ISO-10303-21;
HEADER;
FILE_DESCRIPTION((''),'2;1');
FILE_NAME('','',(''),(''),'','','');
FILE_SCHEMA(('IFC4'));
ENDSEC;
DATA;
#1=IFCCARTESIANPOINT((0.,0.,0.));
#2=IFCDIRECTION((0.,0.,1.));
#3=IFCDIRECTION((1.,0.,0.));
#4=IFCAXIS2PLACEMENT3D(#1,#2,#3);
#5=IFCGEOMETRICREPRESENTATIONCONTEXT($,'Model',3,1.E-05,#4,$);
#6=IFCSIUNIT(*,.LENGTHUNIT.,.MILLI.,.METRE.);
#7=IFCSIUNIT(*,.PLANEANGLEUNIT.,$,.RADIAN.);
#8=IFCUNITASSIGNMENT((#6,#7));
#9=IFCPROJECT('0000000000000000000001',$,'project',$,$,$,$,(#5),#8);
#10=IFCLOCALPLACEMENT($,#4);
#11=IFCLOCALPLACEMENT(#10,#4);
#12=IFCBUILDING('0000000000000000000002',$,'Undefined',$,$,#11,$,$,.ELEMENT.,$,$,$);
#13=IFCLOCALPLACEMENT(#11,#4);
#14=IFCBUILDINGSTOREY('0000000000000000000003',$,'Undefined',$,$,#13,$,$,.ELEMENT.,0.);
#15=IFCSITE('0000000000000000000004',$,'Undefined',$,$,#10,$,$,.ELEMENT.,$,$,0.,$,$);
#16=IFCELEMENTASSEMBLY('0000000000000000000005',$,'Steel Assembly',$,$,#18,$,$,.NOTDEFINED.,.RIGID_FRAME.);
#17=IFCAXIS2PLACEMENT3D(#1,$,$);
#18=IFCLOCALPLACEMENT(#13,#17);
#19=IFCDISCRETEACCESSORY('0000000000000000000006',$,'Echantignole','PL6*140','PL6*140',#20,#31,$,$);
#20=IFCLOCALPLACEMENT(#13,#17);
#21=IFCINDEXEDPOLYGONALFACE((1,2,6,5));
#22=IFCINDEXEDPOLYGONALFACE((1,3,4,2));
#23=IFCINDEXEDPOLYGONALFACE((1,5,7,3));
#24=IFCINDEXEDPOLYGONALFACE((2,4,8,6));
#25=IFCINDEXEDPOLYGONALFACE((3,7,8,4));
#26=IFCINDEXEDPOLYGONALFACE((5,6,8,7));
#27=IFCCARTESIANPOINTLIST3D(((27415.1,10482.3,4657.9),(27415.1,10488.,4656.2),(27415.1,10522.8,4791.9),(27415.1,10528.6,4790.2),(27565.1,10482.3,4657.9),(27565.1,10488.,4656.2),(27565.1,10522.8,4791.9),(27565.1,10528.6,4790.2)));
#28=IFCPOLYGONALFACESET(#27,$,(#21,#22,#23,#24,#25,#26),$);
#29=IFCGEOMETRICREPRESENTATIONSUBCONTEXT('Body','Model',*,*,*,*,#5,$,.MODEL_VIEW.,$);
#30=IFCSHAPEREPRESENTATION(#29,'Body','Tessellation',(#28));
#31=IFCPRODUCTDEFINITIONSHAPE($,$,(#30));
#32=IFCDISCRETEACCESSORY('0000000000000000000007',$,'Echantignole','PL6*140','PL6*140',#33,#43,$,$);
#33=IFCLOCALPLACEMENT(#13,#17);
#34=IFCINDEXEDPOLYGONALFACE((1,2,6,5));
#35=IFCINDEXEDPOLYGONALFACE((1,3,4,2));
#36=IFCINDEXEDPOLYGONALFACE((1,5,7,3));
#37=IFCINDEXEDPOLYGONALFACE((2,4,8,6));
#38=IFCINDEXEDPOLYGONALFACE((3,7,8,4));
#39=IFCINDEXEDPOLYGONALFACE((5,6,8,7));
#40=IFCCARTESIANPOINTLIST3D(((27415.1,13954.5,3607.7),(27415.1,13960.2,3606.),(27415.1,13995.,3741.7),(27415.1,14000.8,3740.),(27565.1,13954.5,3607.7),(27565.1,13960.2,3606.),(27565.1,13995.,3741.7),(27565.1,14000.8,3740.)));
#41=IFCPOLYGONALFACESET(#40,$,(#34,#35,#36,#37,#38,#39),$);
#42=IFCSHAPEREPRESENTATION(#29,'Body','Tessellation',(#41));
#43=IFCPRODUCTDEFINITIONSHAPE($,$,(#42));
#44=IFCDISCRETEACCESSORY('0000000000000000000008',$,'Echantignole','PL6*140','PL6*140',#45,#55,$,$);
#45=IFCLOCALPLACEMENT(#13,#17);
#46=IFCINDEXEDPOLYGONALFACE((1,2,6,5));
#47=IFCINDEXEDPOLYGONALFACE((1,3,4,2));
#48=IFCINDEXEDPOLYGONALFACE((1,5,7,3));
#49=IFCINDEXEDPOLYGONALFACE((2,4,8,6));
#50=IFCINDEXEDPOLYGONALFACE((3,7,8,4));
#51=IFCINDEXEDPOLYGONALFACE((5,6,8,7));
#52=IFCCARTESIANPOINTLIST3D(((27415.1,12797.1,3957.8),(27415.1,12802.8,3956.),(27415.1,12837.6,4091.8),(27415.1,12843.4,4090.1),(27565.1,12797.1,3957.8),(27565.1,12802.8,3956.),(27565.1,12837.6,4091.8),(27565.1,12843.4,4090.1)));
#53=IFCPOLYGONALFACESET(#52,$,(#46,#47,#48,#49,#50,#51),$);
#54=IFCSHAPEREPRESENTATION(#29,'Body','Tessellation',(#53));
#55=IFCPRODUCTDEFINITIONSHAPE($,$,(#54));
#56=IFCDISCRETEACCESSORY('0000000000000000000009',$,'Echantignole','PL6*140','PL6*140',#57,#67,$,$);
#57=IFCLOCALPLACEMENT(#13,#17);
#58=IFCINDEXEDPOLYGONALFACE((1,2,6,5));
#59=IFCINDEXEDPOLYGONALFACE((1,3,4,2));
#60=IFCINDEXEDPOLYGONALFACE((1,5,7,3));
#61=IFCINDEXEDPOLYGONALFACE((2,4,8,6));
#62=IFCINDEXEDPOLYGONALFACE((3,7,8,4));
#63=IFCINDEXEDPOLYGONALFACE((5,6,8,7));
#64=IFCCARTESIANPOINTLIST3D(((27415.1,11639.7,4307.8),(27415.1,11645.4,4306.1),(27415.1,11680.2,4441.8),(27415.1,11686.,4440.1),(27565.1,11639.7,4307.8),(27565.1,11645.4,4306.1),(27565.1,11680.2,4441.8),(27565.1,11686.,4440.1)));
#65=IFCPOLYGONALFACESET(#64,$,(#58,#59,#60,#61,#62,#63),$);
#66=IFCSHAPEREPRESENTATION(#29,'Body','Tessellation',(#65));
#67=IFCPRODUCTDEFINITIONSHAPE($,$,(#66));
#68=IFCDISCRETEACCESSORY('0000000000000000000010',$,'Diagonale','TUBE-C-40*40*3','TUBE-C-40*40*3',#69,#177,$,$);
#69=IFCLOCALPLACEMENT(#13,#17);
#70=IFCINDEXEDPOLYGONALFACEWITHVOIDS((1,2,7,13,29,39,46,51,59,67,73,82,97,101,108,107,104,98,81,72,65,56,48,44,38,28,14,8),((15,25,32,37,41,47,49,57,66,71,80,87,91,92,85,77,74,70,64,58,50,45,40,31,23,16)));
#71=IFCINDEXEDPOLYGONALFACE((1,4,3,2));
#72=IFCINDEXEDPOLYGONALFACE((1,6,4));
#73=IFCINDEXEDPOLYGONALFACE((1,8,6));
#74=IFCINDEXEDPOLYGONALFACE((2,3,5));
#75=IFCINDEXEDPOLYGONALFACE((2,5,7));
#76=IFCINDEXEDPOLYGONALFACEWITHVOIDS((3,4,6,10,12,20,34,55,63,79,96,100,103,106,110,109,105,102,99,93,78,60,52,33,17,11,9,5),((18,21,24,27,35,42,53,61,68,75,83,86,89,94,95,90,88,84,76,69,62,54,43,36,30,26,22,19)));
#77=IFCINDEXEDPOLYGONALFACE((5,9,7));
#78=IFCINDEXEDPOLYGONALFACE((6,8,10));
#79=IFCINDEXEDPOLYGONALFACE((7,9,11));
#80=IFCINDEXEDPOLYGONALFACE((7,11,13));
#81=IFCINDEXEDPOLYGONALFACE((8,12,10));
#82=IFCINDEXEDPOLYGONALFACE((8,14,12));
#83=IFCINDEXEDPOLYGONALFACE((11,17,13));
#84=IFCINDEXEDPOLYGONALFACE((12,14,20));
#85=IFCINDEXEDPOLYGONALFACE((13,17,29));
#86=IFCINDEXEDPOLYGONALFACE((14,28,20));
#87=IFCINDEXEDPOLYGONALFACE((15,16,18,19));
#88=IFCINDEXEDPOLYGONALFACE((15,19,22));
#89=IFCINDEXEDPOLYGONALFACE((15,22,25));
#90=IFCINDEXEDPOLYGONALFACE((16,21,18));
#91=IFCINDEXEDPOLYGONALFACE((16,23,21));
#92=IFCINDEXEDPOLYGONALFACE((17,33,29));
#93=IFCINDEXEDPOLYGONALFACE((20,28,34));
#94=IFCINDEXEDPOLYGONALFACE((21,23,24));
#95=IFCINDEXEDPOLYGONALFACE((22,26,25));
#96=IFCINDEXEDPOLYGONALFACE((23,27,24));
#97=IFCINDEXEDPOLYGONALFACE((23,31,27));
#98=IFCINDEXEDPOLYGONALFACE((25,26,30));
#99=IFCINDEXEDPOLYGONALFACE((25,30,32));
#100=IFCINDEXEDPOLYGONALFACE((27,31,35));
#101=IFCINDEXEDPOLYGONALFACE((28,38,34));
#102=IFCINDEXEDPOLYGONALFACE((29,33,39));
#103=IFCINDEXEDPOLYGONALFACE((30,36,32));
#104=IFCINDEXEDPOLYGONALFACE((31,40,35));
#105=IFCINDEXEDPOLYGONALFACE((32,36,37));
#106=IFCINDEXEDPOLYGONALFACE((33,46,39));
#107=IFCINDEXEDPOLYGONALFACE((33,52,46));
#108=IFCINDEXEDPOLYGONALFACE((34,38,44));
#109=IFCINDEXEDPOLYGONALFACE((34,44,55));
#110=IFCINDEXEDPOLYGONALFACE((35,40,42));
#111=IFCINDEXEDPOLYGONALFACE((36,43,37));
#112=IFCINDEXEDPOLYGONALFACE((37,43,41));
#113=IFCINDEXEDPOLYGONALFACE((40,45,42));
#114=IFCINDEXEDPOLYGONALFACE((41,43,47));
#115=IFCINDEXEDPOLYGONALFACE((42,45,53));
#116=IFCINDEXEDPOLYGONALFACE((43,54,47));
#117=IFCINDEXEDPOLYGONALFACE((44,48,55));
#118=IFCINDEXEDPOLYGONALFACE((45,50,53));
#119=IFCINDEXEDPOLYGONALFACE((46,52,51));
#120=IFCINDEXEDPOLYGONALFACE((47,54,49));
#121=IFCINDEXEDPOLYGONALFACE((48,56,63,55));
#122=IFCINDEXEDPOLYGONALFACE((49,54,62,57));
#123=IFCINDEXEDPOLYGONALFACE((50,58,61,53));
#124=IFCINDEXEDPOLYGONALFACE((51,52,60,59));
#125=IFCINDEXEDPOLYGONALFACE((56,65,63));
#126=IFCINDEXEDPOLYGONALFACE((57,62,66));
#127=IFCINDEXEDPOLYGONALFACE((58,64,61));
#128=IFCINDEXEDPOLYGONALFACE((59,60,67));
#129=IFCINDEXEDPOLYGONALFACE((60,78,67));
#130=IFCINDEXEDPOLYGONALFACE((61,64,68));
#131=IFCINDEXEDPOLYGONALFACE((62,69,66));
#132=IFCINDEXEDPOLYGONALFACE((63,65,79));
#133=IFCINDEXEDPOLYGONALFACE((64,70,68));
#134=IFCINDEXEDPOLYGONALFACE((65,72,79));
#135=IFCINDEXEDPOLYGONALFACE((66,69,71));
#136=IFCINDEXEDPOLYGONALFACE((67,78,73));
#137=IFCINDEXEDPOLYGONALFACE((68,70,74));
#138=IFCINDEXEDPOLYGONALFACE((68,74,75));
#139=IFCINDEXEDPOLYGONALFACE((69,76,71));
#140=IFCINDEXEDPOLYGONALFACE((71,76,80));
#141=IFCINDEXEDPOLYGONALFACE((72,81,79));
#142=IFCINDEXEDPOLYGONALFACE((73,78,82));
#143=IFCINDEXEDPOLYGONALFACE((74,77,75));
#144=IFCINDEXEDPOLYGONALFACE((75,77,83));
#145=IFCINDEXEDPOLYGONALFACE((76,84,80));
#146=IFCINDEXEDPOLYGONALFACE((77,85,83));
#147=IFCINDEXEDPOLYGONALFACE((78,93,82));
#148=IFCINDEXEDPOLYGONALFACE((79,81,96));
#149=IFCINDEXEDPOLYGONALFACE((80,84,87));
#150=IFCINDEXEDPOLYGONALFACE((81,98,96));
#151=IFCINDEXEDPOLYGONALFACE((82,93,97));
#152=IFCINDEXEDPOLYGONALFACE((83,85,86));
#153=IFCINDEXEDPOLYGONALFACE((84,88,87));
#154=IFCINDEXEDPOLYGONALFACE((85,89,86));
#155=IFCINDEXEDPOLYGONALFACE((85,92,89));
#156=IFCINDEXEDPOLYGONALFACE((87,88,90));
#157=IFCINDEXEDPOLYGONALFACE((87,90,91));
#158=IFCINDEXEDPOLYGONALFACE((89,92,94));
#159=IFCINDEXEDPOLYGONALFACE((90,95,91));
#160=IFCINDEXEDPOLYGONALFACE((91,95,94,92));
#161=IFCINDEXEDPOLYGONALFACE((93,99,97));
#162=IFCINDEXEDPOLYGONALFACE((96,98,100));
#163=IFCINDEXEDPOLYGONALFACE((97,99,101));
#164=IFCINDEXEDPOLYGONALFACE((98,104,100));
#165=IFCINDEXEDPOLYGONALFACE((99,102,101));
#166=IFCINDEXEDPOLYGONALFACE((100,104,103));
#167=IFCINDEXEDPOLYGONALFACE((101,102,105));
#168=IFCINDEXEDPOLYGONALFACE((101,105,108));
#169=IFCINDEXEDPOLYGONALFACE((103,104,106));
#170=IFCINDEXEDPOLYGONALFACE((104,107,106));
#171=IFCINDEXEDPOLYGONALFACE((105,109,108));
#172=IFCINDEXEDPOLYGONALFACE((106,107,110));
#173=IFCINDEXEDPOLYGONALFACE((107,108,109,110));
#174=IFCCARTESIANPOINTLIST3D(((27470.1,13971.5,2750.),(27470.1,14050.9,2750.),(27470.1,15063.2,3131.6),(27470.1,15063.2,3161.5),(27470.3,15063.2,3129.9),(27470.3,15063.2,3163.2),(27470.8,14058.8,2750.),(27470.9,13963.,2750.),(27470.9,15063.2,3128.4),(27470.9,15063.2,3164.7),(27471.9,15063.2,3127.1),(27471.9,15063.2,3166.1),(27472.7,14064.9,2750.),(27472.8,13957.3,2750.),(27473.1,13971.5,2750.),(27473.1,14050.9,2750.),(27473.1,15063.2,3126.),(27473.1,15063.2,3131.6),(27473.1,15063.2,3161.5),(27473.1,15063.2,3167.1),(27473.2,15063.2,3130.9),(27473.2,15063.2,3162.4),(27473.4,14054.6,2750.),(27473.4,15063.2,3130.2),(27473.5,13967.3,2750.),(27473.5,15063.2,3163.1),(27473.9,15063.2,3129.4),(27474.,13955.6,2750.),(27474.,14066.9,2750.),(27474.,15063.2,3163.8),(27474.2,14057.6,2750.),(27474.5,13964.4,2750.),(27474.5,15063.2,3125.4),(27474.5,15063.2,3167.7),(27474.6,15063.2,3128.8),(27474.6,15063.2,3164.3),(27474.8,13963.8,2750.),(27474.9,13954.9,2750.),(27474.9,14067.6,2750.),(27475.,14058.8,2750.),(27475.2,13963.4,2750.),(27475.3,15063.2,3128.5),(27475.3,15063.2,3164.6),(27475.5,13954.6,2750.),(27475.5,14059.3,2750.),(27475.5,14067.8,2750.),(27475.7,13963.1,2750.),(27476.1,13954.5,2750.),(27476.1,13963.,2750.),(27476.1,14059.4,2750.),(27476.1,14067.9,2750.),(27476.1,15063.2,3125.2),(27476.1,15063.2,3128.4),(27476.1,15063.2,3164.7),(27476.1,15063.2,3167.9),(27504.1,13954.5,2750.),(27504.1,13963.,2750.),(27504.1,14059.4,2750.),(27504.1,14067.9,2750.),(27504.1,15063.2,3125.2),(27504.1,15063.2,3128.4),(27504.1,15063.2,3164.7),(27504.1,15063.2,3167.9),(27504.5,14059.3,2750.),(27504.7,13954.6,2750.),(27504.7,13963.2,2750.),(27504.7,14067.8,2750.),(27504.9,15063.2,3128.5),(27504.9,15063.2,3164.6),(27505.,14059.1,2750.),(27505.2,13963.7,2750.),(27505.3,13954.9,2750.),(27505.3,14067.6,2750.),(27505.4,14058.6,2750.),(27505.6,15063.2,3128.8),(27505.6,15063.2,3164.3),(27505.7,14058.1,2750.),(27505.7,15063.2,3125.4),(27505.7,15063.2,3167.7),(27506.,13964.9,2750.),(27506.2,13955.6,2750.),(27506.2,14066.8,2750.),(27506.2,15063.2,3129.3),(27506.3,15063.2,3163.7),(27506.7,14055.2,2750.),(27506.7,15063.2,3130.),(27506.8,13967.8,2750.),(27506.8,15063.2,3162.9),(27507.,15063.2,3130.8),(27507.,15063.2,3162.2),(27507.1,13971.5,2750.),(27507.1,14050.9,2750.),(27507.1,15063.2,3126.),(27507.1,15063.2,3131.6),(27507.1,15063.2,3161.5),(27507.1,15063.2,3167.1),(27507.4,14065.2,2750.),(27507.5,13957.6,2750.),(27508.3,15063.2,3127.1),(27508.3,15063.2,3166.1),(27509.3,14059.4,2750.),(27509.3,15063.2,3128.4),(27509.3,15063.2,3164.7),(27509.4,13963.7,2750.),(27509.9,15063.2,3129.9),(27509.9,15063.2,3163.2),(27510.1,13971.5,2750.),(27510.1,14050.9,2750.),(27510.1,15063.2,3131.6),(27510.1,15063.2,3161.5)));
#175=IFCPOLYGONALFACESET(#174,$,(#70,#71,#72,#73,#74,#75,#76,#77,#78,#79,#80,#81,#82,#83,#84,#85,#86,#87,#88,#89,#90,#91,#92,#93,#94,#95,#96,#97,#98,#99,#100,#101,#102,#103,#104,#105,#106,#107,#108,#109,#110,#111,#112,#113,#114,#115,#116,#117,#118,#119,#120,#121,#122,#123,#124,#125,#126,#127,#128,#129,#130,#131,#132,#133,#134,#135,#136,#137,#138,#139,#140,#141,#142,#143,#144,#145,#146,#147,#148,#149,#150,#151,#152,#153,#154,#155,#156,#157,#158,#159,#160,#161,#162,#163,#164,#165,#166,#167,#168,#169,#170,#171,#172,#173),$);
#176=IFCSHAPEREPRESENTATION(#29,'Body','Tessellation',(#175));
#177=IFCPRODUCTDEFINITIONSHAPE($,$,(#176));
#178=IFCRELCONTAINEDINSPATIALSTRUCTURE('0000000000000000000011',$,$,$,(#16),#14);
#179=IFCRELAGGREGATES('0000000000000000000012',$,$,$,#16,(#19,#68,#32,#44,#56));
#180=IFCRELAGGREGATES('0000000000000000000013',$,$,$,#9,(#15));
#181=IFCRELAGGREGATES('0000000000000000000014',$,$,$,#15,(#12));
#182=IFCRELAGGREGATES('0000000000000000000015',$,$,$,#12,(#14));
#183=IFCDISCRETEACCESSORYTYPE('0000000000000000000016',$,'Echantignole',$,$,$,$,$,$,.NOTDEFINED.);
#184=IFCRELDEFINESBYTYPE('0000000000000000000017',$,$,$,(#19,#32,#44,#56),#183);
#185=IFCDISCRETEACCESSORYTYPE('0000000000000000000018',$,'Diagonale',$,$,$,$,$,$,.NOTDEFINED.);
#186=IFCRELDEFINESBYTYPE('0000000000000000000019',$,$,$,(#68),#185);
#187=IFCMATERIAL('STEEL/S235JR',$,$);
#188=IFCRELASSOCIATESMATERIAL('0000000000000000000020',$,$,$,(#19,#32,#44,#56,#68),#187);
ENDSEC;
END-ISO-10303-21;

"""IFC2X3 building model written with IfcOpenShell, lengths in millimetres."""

from ifc_helpers import new_model, si_unit, frame, origin_with_axes, origin_2d_with_axis, place, context, subcontext, project, spatial, polyline, hollow_rectangle, outline, extrude, clip, halfspace, material, type_object, element, aggregate, save


model = new_model("IFC2X3")

# Units and contexts
model_context = context("Model", 3, precision=1e-05, world=origin_with_axes())
body_context = subcontext(model_context, "Body", "Model", "MODEL_VIEW")
ifc_project = project(units=[si_unit("LENGTHUNIT", "METRE", prefix="MILLI"), si_unit("PLANEANGLEUNIT", "RADIAN")], contexts=[model_context])

# Site, building, storey
site_placement = place(None, origin_with_axes())
site = spatial("IfcSite", under=ifc_project, at=site_placement, Name="Undefined", CompositionType="ELEMENT", RefElevation=0.0)
building_placement = place(site_placement, origin_with_axes())
building = spatial("IfcBuilding", under=site, at=building_placement, Name="Undefined", CompositionType="ELEMENT")
storey_placement = place(building_placement, origin_with_axes())
storey = spatial("IfcBuildingStorey", under=building, at=storey_placement, Name="Undefined", CompositionType="ELEMENT", Elevation=0.0)

# Element assembly, discrete accessories
assembly_1_placement = place(storey_placement, origin_with_axes())
assembly_1 = element("IfcElementAssembly", 1, at=assembly_1_placement, inside=storey, Name="Steel Assembly", AssemblyPlace="NOTDEFINED", PredefinedType="RIGID_FRAME")
ifc_material_1 = material(Name="STEEL/S235JR")
discrete_accessory_type_1 = type_object("IfcDiscreteAccessoryType", Name="Echantignole")
discrete_accessory_1_placement = place(assembly_1_placement, frame((27565.1, 10505.4, 4724.0), z_axis=(0.0, 0.957179, -0.289497), x_axis=(-1.0, 0.0, 0.0)))
discrete_accessory_1 = element("IfcDiscreteAccessory", 2, at=discrete_accessory_1_placement, type_object=discrete_accessory_type_1, material=ifc_material_1, Name="Echantignole", Description="PL6*140", ObjectType="PL6*140", context=body_context, shape_type="SweptSolid", body=[
    extrude(outline(polyline([(0.0, -70.0), (0.0, 70.0), (150.0, 70.0), (150.0, -70.0), (0.0, -70.0)])), frame((0.0, 0.0, -3.0), z_axis=(0.0, 0.0, 1.0), x_axis=(1.0, 0.0, 0.0)), (0.0, 0.0, 1.0), 6.0),
])
discrete_accessory_2_placement = place(assembly_1_placement, frame((27565.1, 13977.6, 3673.9), z_axis=(0.0, 0.957179, -0.289497), x_axis=(-1.0, 0.0, 0.0)))
discrete_accessory_2 = element("IfcDiscreteAccessory", 3, at=discrete_accessory_2_placement, type_object=discrete_accessory_type_1, material=ifc_material_1, Name="Echantignole", Description="PL6*140", ObjectType="PL6*140", context=body_context, shape_type="SweptSolid", body=[
    extrude(outline(polyline([(0.0, -70.0), (0.0, 70.0), (150.0, 70.0), (150.0, -70.0), (0.0, -70.0)])), frame((0.0, 0.0, -3.0), z_axis=(0.0, 0.0, 1.0), x_axis=(1.0, 0.0, 0.0)), (0.0, 0.0, 1.0), 6.0),
])
discrete_accessory_3_placement = place(assembly_1_placement, frame((27565.1, 12820.2, 4023.9), z_axis=(0.0, 0.957179, -0.289497), x_axis=(-1.0, 0.0, 0.0)))
discrete_accessory_3 = element("IfcDiscreteAccessory", 4, at=discrete_accessory_3_placement, type_object=discrete_accessory_type_1, material=ifc_material_1, Name="Echantignole", Description="PL6*140", ObjectType="PL6*140", context=body_context, shape_type="SweptSolid", body=[
    extrude(outline(polyline([(0.0, -70.0), (0.0, 70.0), (150.0, 70.0), (150.0, -70.0), (0.0, -70.0)])), frame((0.0, 0.0, -3.0), z_axis=(0.0, 0.0, 1.0), x_axis=(1.0, 0.0, 0.0)), (0.0, 0.0, 1.0), 6.0),
])
discrete_accessory_4_placement = place(assembly_1_placement, frame((27565.1, 11662.8, 4374.0), z_axis=(0.0, 0.957179, -0.289497), x_axis=(-1.0, 0.0, 0.0)))
discrete_accessory_4 = element("IfcDiscreteAccessory", 5, at=discrete_accessory_4_placement, type_object=discrete_accessory_type_1, material=ifc_material_1, Name="Echantignole", Description="PL6*140", ObjectType="PL6*140", context=body_context, shape_type="SweptSolid", body=[
    extrude(outline(polyline([(0.0, -70.0), (0.0, 70.0), (150.0, 70.0), (150.0, -70.0), (0.0, -70.0)])), frame((0.0, 0.0, -3.0), z_axis=(0.0, 0.0, 1.0), x_axis=(1.0, 0.0, 0.0)), (0.0, 0.0, 1.0), 6.0),
])
discrete_accessory_type_2 = type_object("IfcDiscreteAccessoryType", Name="Diagonale")
discrete_accessory_5_placement = place(assembly_1_placement, frame((27490.1, 13961.6, 2731.3), z_axis=(0.0, -0.352745, 0.93572), x_axis=(0.0, 0.93572, 0.352745)))
discrete_accessory_5 = element("IfcDiscreteAccessory", 6, at=discrete_accessory_5_placement, type_object=discrete_accessory_type_2, material=ifc_material_1, Name="Diagonale", Description="TUBE-C-40*40*3", ObjectType="TUBE-C-40*40*3", context=body_context, shape_type="Clipping", body=[
    clip(clip(extrude(hollow_rectangle(XDim=40.0, YDim=40.0, WallThickness=3.0, InnerFilletRadius=3.0, OuterFilletRadius=6.0, at=origin_2d_with_axis()), frame((1238.5, 0.0, 0.0), z_axis=(-1.0, 0.0, 0.0), x_axis=(0.0, -1.0, 0.0)), (0.0, 0.0, 1.0), 1246.6), halfspace(frame((1146.9, 0.0, -80.5), z_axis=(0.93572, 0.0, -0.352745), x_axis=(0.0, -1.0, 0.0)), False)), halfspace(frame((172.4, 0.0, -45.0), z_axis=(0.352745, 0.0, 0.93572), x_axis=(0.0, -1.0, 0.0)), True)),
])

aggregate(assembly_1, [discrete_accessory_1, discrete_accessory_5, discrete_accessory_2, discrete_accessory_3, discrete_accessory_4])

save(model, "model.ifc")
